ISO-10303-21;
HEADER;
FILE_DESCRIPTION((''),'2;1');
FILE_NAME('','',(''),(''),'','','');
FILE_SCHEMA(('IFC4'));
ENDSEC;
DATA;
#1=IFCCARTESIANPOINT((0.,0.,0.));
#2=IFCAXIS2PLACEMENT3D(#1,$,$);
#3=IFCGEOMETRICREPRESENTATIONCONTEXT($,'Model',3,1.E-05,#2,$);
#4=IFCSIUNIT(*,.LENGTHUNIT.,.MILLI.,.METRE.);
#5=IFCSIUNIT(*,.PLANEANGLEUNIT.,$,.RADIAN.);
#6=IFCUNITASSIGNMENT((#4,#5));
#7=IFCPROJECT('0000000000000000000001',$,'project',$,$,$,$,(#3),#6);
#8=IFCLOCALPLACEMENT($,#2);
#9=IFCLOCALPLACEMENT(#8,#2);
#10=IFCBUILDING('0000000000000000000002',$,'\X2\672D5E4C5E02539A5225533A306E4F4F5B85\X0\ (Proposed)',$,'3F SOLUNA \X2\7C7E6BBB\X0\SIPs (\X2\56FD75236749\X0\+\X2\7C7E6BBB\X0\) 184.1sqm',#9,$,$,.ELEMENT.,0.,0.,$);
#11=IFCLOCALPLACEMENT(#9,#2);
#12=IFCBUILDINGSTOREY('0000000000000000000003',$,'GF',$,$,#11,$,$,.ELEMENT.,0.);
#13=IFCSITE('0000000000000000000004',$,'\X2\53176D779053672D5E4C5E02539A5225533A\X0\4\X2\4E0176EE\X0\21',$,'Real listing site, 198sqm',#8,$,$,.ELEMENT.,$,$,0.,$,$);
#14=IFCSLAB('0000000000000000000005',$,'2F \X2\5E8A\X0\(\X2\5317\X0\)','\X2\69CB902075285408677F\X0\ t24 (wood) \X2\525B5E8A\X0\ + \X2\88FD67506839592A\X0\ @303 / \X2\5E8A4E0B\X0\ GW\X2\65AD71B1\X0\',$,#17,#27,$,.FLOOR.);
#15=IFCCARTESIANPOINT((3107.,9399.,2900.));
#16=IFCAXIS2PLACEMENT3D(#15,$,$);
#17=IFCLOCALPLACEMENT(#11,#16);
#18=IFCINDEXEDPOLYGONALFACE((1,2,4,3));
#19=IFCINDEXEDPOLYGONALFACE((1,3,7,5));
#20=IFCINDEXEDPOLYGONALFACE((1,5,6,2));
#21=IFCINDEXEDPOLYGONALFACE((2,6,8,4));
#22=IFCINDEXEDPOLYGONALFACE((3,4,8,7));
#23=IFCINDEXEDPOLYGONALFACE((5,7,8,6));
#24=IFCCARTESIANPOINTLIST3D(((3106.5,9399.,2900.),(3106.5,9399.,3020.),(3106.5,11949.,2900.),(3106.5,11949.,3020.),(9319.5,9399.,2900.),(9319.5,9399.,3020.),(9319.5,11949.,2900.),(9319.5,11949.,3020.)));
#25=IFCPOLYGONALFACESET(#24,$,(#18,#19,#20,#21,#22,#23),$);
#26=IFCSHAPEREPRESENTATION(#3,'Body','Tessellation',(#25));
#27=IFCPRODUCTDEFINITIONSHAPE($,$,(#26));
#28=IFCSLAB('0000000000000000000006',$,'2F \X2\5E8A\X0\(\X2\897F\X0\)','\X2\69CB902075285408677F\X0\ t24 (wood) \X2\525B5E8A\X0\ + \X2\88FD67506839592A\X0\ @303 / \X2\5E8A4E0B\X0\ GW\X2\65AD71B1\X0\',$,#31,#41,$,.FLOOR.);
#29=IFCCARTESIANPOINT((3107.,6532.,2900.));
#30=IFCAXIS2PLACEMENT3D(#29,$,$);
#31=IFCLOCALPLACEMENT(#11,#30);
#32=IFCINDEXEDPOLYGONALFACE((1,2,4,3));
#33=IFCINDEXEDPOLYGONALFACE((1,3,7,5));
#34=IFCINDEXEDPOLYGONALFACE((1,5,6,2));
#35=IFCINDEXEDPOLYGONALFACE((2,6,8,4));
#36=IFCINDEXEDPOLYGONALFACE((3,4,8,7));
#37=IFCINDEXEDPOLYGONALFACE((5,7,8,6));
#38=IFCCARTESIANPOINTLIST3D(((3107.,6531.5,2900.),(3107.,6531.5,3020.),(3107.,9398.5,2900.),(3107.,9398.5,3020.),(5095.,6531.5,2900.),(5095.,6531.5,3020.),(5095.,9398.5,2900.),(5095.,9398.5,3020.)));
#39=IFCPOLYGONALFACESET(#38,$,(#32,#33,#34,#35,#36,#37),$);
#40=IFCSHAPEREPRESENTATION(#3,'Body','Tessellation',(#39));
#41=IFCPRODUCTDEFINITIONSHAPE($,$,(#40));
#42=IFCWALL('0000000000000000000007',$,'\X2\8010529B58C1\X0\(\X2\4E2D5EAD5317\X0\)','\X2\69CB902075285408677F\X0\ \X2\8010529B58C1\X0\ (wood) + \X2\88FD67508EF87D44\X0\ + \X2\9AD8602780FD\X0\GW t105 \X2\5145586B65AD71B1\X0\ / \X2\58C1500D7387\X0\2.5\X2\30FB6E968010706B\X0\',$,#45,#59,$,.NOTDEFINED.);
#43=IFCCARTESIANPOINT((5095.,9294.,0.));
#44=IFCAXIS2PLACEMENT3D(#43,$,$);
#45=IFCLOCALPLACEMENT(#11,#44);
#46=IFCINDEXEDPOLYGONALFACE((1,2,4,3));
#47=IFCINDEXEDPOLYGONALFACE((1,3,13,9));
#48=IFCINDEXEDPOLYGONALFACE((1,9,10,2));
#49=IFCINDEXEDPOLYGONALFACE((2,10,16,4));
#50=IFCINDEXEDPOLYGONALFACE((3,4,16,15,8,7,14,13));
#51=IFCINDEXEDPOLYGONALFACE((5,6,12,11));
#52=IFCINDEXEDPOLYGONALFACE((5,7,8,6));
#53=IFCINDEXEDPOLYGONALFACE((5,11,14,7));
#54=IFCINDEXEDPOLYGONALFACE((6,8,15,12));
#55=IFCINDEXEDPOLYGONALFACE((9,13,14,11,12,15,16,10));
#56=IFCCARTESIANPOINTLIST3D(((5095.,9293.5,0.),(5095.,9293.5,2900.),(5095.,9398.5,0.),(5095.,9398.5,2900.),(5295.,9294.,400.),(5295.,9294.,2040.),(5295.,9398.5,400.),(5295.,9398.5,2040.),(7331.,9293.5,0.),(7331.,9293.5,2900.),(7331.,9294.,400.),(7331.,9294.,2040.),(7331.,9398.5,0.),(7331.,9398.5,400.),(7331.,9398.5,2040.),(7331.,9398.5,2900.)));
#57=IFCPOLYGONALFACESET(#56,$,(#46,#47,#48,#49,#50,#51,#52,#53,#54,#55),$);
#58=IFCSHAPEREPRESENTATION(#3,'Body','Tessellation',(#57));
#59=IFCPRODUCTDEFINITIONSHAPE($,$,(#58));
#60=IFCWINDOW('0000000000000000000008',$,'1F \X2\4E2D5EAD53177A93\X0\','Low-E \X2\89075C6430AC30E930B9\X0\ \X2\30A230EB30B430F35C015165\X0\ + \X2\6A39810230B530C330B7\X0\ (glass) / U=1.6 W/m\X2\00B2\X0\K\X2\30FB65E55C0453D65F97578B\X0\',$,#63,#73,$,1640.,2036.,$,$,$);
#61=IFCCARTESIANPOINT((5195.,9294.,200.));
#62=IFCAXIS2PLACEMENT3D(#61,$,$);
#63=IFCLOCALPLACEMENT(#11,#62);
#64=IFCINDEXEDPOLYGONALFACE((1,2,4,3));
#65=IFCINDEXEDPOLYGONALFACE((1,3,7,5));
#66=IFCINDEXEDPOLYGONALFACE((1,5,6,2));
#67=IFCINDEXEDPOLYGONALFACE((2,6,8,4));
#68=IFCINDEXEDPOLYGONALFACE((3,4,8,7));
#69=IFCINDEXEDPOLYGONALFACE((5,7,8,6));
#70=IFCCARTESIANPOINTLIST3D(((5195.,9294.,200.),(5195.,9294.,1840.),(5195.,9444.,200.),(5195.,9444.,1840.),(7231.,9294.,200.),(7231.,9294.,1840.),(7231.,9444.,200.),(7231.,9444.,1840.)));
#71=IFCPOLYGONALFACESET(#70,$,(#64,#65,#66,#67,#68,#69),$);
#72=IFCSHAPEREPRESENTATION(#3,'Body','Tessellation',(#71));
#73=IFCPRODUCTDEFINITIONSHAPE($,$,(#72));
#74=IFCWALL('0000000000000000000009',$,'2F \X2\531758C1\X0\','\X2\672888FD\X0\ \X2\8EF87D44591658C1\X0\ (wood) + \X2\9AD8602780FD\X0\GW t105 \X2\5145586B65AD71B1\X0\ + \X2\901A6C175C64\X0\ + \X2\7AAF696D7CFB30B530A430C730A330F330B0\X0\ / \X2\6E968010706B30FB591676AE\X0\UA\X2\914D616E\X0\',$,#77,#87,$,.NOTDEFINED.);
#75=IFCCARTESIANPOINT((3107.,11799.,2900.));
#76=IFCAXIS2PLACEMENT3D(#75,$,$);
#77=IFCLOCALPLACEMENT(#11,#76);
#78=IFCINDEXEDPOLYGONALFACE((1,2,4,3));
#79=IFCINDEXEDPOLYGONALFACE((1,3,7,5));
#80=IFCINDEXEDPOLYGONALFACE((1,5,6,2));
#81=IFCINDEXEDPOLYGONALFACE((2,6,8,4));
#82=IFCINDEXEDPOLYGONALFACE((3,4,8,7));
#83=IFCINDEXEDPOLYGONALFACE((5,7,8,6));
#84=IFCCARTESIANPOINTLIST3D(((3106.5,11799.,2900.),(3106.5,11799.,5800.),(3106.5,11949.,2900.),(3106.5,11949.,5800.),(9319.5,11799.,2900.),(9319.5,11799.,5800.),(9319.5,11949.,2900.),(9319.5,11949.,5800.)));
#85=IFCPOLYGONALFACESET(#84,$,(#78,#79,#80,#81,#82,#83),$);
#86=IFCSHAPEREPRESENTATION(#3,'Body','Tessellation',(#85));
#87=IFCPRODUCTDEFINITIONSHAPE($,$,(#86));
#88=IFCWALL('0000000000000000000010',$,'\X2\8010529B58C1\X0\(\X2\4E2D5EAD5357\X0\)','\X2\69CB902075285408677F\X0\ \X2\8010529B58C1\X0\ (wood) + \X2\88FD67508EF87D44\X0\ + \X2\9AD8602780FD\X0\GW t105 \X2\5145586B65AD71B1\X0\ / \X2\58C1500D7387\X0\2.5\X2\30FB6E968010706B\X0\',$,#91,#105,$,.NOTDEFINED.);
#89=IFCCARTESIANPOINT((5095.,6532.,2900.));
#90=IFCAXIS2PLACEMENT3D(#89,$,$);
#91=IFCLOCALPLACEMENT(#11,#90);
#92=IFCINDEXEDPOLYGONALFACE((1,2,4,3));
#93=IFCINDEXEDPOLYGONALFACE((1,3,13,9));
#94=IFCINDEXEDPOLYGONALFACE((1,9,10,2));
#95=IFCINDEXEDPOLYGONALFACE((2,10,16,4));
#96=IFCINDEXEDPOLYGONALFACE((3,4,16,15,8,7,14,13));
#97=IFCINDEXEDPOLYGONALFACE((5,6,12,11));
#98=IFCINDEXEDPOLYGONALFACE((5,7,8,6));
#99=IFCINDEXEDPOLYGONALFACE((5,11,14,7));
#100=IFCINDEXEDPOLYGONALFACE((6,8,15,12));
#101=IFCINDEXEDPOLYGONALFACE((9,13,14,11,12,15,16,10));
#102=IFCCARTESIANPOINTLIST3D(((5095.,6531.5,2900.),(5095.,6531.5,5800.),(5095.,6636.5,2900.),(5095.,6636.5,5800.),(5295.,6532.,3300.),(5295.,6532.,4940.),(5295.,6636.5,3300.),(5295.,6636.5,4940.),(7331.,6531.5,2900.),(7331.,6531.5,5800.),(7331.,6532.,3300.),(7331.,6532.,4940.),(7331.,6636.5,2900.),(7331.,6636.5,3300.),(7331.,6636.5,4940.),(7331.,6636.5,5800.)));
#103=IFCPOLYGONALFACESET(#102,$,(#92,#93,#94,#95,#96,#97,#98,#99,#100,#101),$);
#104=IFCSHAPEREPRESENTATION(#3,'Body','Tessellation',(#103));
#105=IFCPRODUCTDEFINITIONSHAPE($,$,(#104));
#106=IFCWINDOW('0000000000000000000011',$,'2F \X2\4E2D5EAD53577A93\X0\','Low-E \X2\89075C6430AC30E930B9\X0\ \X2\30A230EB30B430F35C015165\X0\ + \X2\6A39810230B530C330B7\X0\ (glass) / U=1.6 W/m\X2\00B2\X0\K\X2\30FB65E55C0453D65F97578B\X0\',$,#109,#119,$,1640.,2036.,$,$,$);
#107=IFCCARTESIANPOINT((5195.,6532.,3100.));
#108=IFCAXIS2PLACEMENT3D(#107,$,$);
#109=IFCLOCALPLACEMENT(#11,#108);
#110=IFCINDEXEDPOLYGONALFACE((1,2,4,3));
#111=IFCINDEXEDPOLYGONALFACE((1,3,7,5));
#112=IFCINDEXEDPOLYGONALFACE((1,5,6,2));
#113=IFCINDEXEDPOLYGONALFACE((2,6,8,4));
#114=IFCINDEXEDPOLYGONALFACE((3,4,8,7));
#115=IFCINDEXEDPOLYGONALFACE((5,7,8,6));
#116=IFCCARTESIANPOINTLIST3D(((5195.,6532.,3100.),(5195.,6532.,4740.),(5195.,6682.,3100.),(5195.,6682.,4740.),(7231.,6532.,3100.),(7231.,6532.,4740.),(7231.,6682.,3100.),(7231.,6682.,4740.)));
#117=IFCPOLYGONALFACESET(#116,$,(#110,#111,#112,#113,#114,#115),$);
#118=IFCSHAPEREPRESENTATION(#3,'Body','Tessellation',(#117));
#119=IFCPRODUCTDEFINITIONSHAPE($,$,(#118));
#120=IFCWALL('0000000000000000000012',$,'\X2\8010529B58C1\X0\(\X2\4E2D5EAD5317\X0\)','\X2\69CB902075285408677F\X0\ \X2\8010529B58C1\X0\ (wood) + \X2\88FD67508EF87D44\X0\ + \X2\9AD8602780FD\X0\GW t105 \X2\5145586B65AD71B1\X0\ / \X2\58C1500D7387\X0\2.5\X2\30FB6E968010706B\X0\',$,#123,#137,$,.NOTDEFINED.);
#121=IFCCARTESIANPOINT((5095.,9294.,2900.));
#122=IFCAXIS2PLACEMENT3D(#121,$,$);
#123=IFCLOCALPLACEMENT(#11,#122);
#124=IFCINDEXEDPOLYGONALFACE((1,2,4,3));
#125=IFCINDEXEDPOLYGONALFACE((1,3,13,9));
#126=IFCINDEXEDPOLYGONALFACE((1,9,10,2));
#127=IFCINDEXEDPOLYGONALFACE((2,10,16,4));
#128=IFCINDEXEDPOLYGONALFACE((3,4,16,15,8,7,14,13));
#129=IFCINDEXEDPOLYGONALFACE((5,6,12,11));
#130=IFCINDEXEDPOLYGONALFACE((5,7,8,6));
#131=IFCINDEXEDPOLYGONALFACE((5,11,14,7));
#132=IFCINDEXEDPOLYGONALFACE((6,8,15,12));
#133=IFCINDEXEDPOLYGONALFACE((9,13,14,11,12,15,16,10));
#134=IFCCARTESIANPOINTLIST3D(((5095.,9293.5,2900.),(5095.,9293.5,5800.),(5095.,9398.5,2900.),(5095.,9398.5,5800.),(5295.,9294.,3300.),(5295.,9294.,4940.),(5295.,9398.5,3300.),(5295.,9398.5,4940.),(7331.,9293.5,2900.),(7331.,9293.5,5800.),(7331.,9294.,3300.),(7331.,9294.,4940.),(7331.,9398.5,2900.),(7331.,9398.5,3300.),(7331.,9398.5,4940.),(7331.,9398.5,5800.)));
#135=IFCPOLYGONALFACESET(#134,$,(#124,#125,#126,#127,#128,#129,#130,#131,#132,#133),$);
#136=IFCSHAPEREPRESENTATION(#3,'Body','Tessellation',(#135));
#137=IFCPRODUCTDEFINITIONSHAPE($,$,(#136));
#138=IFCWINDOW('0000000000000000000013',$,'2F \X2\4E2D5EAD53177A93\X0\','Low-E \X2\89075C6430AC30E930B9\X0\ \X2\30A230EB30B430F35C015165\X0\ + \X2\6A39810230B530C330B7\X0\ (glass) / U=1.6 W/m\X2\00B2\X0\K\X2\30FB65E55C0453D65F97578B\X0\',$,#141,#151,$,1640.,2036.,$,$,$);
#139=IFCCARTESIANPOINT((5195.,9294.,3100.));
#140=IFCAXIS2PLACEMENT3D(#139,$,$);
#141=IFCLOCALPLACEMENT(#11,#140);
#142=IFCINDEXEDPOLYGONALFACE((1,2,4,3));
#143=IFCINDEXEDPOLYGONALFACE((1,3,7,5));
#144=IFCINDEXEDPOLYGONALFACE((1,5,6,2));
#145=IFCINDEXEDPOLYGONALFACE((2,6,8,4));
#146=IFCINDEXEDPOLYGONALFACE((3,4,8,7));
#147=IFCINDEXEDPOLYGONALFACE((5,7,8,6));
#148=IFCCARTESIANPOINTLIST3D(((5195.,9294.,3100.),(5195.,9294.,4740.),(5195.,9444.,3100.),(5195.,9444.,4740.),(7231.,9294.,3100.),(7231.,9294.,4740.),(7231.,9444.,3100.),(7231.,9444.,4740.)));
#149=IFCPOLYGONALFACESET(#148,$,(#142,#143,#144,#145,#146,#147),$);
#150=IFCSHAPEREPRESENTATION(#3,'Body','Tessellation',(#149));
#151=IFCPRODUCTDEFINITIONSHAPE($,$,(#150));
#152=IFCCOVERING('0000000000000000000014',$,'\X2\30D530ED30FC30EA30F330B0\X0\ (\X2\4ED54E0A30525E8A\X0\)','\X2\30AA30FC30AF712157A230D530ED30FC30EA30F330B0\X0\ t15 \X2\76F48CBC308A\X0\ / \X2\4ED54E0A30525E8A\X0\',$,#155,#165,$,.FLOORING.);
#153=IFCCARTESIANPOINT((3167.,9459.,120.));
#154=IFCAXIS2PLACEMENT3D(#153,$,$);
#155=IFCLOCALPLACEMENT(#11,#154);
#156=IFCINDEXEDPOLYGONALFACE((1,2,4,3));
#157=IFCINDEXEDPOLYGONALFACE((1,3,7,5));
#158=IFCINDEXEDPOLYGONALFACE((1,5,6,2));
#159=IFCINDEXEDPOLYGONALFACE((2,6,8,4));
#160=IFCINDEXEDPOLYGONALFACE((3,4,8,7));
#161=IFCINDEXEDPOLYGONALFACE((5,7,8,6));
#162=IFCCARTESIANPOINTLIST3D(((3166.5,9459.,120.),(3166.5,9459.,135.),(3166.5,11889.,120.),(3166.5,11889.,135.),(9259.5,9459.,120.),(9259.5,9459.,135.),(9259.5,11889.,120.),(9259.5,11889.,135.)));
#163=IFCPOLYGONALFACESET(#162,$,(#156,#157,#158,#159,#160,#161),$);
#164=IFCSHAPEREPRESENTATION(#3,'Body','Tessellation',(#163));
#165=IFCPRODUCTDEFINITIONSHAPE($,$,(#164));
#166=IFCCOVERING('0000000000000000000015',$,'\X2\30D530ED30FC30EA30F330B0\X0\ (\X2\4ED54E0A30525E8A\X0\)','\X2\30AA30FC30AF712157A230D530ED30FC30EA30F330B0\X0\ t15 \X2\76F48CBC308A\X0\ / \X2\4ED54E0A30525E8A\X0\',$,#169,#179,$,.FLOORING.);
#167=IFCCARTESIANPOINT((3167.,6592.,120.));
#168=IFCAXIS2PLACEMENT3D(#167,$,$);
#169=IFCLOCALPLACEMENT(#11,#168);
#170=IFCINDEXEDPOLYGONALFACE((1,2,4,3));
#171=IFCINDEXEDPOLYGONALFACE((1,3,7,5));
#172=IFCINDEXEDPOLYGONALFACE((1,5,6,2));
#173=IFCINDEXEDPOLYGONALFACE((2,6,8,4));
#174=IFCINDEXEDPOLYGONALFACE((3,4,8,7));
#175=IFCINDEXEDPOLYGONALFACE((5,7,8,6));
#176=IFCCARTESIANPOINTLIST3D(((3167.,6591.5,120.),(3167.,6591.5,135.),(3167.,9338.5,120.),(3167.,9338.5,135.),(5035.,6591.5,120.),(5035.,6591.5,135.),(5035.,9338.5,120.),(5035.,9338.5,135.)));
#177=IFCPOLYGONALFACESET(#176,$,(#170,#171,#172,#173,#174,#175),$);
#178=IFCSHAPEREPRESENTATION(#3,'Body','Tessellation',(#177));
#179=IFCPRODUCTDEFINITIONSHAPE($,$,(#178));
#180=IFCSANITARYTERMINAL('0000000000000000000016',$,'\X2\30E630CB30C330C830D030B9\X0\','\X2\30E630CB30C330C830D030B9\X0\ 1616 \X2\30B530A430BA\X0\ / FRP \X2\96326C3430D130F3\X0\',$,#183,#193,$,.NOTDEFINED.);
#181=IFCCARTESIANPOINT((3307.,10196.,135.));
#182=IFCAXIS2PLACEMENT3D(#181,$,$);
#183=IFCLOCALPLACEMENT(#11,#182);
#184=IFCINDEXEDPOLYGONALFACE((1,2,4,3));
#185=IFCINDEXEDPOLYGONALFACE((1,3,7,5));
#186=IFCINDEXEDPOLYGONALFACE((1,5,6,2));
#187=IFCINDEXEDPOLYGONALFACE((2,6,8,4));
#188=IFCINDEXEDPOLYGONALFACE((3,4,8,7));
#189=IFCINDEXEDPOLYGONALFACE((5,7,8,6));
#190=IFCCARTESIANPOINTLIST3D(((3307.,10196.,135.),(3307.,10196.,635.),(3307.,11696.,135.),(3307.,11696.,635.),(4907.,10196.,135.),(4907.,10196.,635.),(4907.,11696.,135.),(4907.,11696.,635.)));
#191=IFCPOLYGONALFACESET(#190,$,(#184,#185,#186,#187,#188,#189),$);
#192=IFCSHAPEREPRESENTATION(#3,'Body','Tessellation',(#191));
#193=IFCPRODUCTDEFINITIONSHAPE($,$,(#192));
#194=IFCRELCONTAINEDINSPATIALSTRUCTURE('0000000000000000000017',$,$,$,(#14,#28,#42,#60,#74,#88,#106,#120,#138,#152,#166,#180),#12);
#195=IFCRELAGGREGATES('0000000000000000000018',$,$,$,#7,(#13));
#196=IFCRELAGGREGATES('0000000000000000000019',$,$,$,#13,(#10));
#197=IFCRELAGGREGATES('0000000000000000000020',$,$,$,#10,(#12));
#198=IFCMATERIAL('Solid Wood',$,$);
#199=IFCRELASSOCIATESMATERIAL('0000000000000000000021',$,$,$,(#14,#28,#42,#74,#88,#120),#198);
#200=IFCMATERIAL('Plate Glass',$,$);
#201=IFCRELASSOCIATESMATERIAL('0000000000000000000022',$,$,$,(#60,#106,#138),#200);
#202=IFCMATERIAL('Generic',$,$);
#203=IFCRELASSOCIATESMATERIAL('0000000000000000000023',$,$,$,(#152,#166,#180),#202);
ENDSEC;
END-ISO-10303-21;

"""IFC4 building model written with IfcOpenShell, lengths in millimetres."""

from ifc_helpers import new_model, si_unit, frame, frame_2d, origin, place, context, project, spatial, rectangle, extrude, material, element, fill, save


model = new_model("IFC4")

# Units and contexts
model_context = context("Model", 3, precision=1e-05, world=origin())
ifc_project = project(units=[si_unit("LENGTHUNIT", "METRE", prefix="MILLI"), si_unit("PLANEANGLEUNIT", "RADIAN")], contexts=[model_context])

# Site, building, storey
site_placement = place(None, origin())
site = spatial("IfcSite", under=ifc_project, at=site_placement, Name="北海道札幌市厚別区4丁目21", ObjectType="Real listing site, 198sqm", CompositionType="ELEMENT", RefElevation=0.0)
building_placement = place(site_placement, origin())
building = spatial("IfcBuilding", under=site, at=building_placement, Name="札幌市厚別区の住宅 (Proposed)", ObjectType="3F SOLUNA 籾殻SIPs (国産杉+籾殻) 184.1sqm", CompositionType="ELEMENT", ElevationOfRefHeight=0.0, ElevationOfTerrain=0.0)
storey_placement = place(building_placement, origin())
storey = spatial("IfcBuildingStorey", under=building, at=storey_placement, Name="GF", CompositionType="ELEMENT", Elevation=0.0)

# Slabs
ifc_material_1 = material(Name="Solid Wood")
slab_1_placement = place(storey_placement, frame((3107.0, 9399.0, 2900.0)))
element("IfcSlab", 1, at=slab_1_placement, inside=storey, material=ifc_material_1, Name="2F 床(北)", Description="構造用合板 t24 (wood) 剛床 + 製材根太 @303 / 床下 GW断熱", PredefinedType="FLOOR", context=model_context, shape_type="SweptSolid", body=[
    extrude(rectangle(XDim=6213.0, YDim=2550.0, at=frame_2d((3106.0, 1275.0))), frame((3107.0, 9399.0, 2900.0)), (0.0, 0.0, 1.0), 120.0),
])
slab_2_placement = place(storey_placement, frame((3107.0, 6532.0, 2900.0)))
element("IfcSlab", 2, at=slab_2_placement, inside=storey, material=ifc_material_1, Name="2F 床(西)", Description="構造用合板 t24 (wood) 剛床 + 製材根太 @303 / 床下 GW断熱", PredefinedType="FLOOR", context=model_context, shape_type="SweptSolid", body=[
    extrude(rectangle(XDim=1988.0, YDim=2867.0, at=frame_2d((994.0, 1433.0))), frame((3107.0, 6532.0, 2900.0)), (0.0, 0.0, 1.0), 120.0),
])

# Wall, opening, window
wall_1_placement = place(storey_placement, frame((5095.0, 9294.0, 0.0)))
wall_1 = element("IfcWall", 3, at=wall_1_placement, inside=storey, material=ifc_material_1, Name="耐力壁(中庭北)", Description="構造用合板 耐力壁 (wood) + 製材軸組 + 高性能GW t105 充填断熱 / 壁倍率2.5・準耐火", PredefinedType="NOTDEFINED", context=model_context, shape_type="SweptSolid", body=[
    extrude(rectangle(XDim=2236.0, YDim=105.0, at=frame_2d((1118.0, 52.0))), frame((5095.0, 9294.0, 0.0)), (0.0, 0.0, 1.0), 2900.0),
])
opening_1_placement = place(storey_placement, frame((5195.0, 9294.0, 200.0)))
opening_1 = element("IfcOpeningElement", 4, at=opening_1_placement, cuts=wall_1, PredefinedType="NOTDEFINED", context=model_context, shape_type="SweptSolid", body=[
    extrude(rectangle(XDim=2036.0, YDim=150.0, at=frame_2d((1018.0, 75.0))), frame((5195.0, 9294.0, 200.0)), (0.0, 0.0, 1.0), 1640.0),
])
ifc_material_2 = material(Name="Plate Glass")
window_1_placement = place(storey_placement, frame((5195.0, 9294.0, 200.0)))
window_1 = element("IfcWindow", 5, at=window_1_placement, inside=storey, material=ifc_material_2, Name="1F 中庭北窓", Description="Low-E 複層ガラス アルゴン封入 + 樹脂サッシ (glass) / U=1.6 W/m²K・日射取得型", OverallHeight=1640.0, OverallWidth=2036.0, context=model_context, shape_type="SweptSolid", body=[
    extrude(rectangle(XDim=2036.0, YDim=150.0, at=frame_2d((1018.0, 75.0))), frame((5195.0, 9294.0, 200.0)), (0.0, 0.0, 1.0), 1640.0),
])
fill(opening_1, window_1)

# Wall
wall_2_placement = place(storey_placement, frame((3107.0, 11799.0, 2900.0)))
element("IfcWall", 6, at=wall_2_placement, inside=storey, material=ifc_material_1, Name="2F 北壁", Description="木製 軸組外壁 (wood) + 高性能GW t105 充填断熱 + 通気層 + 窯業系サイディング / 準耐火・外皮UA配慮", PredefinedType="NOTDEFINED", context=model_context, shape_type="SweptSolid", body=[
    extrude(rectangle(XDim=6213.0, YDim=150.0, at=frame_2d((3106.0, 75.0))), frame((3107.0, 11799.0, 2900.0)), (0.0, 0.0, 1.0), 2900.0),
])

# Walls, openings, windows
wall_3_placement = place(storey_placement, frame((5095.0, 6532.0, 2900.0)))
wall_3 = element("IfcWall", 7, at=wall_3_placement, inside=storey, material=ifc_material_1, Name="耐力壁(中庭南)", Description="構造用合板 耐力壁 (wood) + 製材軸組 + 高性能GW t105 充填断熱 / 壁倍率2.5・準耐火", PredefinedType="NOTDEFINED", context=model_context, shape_type="SweptSolid", body=[
    extrude(rectangle(XDim=2236.0, YDim=105.0, at=frame_2d((1118.0, 52.0))), frame((5095.0, 6532.0, 2900.0)), (0.0, 0.0, 1.0), 2900.0),
])
opening_2_placement = place(storey_placement, frame((5195.0, 6532.0, 3100.0)))
opening_2 = element("IfcOpeningElement", 8, at=opening_2_placement, cuts=wall_3, PredefinedType="NOTDEFINED", context=model_context, shape_type="SweptSolid", body=[
    extrude(rectangle(XDim=2036.0, YDim=150.0, at=frame_2d((1018.0, 75.0))), frame((5195.0, 6532.0, 3100.0)), (0.0, 0.0, 1.0), 1640.0),
])
window_2_placement = place(storey_placement, frame((5195.0, 6532.0, 3100.0)))
window_2 = element("IfcWindow", 9, at=window_2_placement, inside=storey, material=ifc_material_2, Name="2F 中庭南窓", Description="Low-E 複層ガラス アルゴン封入 + 樹脂サッシ (glass) / U=1.6 W/m²K・日射取得型", OverallHeight=1640.0, OverallWidth=2036.0, context=model_context, shape_type="SweptSolid", body=[
    extrude(rectangle(XDim=2036.0, YDim=150.0, at=frame_2d((1018.0, 75.0))), frame((5195.0, 6532.0, 3100.0)), (0.0, 0.0, 1.0), 1640.0),
])
fill(opening_2, window_2)
wall_4_placement = place(storey_placement, frame((5095.0, 9294.0, 2900.0)))
wall_4 = element("IfcWall", 10, at=wall_4_placement, inside=storey, material=ifc_material_1, Name="耐力壁(中庭北)", Description="構造用合板 耐力壁 (wood) + 製材軸組 + 高性能GW t105 充填断熱 / 壁倍率2.5・準耐火", PredefinedType="NOTDEFINED", context=model_context, shape_type="SweptSolid", body=[
    extrude(rectangle(XDim=2236.0, YDim=105.0, at=frame_2d((1118.0, 52.0))), frame((5095.0, 9294.0, 2900.0)), (0.0, 0.0, 1.0), 2900.0),
])
opening_3_placement = place(storey_placement, frame((5195.0, 9294.0, 3100.0)))
opening_3 = element("IfcOpeningElement", 11, at=opening_3_placement, cuts=wall_4, PredefinedType="NOTDEFINED", context=model_context, shape_type="SweptSolid", body=[
    extrude(rectangle(XDim=2036.0, YDim=150.0, at=frame_2d((1018.0, 75.0))), frame((5195.0, 9294.0, 3100.0)), (0.0, 0.0, 1.0), 1640.0),
])
window_3_placement = place(storey_placement, frame((5195.0, 9294.0, 3100.0)))
window_3 = element("IfcWindow", 12, at=window_3_placement, inside=storey, material=ifc_material_2, Name="2F 中庭北窓", Description="Low-E 複層ガラス アルゴン封入 + 樹脂サッシ (glass) / U=1.6 W/m²K・日射取得型", OverallHeight=1640.0, OverallWidth=2036.0, context=model_context, shape_type="SweptSolid", body=[
    extrude(rectangle(XDim=2036.0, YDim=150.0, at=frame_2d((1018.0, 75.0))), frame((5195.0, 9294.0, 3100.0)), (0.0, 0.0, 1.0), 1640.0),
])
fill(opening_3, window_3)

# Coverings
ifc_material_3 = material(Name="Generic")
covering_1_placement = place(storey_placement, frame((3167.0, 9459.0, 120.0)))
element("IfcCovering", 13, at=covering_1_placement, inside=storey, material=ifc_material_3, Name="フローリング (仕上げ床)", Description="オーク無垢フローリング t15 直貼り / 仕上げ床", PredefinedType="FLOORING", context=model_context, shape_type="SweptSolid", body=[
    extrude(rectangle(XDim=6093.0, YDim=2430.0, at=frame_2d((3046.0, 1215.0))), frame((3167.0, 9459.0, 120.0)), (0.0, 0.0, 1.0), 15.0),
])
covering_2_placement = place(storey_placement, frame((3167.0, 6592.0, 120.0)))
element("IfcCovering", 14, at=covering_2_placement, inside=storey, material=ifc_material_3, Name="フローリング (仕上げ床)", Description="オーク無垢フローリング t15 直貼り / 仕上げ床", PredefinedType="FLOORING", context=model_context, shape_type="SweptSolid", body=[
    extrude(rectangle(XDim=1868.0, YDim=2747.0, at=frame_2d((934.0, 1373.0))), frame((3167.0, 6592.0, 120.0)), (0.0, 0.0, 1.0), 15.0),
])

# Sanitary terminal
sanitary_terminal_1_placement = place(storey_placement, frame((3307.0, 10196.0, 135.0)))
element("IfcSanitaryTerminal", 15, at=sanitary_terminal_1_placement, inside=storey, material=ifc_material_3, Name="ユニットバス", Description="ユニットバス 1616 サイズ / FRP 防水パン", PredefinedType="NOTDEFINED", context=model_context, shape_type="SweptSolid", body=[
    extrude(rectangle(XDim=1600.0, YDim=1500.0, at=frame_2d((800.0, 750.0))), frame((3307.0, 10196.0, 135.0)), (0.0, 0.0, 1.0), 500.0),
])

save(model, "model.ifc")
